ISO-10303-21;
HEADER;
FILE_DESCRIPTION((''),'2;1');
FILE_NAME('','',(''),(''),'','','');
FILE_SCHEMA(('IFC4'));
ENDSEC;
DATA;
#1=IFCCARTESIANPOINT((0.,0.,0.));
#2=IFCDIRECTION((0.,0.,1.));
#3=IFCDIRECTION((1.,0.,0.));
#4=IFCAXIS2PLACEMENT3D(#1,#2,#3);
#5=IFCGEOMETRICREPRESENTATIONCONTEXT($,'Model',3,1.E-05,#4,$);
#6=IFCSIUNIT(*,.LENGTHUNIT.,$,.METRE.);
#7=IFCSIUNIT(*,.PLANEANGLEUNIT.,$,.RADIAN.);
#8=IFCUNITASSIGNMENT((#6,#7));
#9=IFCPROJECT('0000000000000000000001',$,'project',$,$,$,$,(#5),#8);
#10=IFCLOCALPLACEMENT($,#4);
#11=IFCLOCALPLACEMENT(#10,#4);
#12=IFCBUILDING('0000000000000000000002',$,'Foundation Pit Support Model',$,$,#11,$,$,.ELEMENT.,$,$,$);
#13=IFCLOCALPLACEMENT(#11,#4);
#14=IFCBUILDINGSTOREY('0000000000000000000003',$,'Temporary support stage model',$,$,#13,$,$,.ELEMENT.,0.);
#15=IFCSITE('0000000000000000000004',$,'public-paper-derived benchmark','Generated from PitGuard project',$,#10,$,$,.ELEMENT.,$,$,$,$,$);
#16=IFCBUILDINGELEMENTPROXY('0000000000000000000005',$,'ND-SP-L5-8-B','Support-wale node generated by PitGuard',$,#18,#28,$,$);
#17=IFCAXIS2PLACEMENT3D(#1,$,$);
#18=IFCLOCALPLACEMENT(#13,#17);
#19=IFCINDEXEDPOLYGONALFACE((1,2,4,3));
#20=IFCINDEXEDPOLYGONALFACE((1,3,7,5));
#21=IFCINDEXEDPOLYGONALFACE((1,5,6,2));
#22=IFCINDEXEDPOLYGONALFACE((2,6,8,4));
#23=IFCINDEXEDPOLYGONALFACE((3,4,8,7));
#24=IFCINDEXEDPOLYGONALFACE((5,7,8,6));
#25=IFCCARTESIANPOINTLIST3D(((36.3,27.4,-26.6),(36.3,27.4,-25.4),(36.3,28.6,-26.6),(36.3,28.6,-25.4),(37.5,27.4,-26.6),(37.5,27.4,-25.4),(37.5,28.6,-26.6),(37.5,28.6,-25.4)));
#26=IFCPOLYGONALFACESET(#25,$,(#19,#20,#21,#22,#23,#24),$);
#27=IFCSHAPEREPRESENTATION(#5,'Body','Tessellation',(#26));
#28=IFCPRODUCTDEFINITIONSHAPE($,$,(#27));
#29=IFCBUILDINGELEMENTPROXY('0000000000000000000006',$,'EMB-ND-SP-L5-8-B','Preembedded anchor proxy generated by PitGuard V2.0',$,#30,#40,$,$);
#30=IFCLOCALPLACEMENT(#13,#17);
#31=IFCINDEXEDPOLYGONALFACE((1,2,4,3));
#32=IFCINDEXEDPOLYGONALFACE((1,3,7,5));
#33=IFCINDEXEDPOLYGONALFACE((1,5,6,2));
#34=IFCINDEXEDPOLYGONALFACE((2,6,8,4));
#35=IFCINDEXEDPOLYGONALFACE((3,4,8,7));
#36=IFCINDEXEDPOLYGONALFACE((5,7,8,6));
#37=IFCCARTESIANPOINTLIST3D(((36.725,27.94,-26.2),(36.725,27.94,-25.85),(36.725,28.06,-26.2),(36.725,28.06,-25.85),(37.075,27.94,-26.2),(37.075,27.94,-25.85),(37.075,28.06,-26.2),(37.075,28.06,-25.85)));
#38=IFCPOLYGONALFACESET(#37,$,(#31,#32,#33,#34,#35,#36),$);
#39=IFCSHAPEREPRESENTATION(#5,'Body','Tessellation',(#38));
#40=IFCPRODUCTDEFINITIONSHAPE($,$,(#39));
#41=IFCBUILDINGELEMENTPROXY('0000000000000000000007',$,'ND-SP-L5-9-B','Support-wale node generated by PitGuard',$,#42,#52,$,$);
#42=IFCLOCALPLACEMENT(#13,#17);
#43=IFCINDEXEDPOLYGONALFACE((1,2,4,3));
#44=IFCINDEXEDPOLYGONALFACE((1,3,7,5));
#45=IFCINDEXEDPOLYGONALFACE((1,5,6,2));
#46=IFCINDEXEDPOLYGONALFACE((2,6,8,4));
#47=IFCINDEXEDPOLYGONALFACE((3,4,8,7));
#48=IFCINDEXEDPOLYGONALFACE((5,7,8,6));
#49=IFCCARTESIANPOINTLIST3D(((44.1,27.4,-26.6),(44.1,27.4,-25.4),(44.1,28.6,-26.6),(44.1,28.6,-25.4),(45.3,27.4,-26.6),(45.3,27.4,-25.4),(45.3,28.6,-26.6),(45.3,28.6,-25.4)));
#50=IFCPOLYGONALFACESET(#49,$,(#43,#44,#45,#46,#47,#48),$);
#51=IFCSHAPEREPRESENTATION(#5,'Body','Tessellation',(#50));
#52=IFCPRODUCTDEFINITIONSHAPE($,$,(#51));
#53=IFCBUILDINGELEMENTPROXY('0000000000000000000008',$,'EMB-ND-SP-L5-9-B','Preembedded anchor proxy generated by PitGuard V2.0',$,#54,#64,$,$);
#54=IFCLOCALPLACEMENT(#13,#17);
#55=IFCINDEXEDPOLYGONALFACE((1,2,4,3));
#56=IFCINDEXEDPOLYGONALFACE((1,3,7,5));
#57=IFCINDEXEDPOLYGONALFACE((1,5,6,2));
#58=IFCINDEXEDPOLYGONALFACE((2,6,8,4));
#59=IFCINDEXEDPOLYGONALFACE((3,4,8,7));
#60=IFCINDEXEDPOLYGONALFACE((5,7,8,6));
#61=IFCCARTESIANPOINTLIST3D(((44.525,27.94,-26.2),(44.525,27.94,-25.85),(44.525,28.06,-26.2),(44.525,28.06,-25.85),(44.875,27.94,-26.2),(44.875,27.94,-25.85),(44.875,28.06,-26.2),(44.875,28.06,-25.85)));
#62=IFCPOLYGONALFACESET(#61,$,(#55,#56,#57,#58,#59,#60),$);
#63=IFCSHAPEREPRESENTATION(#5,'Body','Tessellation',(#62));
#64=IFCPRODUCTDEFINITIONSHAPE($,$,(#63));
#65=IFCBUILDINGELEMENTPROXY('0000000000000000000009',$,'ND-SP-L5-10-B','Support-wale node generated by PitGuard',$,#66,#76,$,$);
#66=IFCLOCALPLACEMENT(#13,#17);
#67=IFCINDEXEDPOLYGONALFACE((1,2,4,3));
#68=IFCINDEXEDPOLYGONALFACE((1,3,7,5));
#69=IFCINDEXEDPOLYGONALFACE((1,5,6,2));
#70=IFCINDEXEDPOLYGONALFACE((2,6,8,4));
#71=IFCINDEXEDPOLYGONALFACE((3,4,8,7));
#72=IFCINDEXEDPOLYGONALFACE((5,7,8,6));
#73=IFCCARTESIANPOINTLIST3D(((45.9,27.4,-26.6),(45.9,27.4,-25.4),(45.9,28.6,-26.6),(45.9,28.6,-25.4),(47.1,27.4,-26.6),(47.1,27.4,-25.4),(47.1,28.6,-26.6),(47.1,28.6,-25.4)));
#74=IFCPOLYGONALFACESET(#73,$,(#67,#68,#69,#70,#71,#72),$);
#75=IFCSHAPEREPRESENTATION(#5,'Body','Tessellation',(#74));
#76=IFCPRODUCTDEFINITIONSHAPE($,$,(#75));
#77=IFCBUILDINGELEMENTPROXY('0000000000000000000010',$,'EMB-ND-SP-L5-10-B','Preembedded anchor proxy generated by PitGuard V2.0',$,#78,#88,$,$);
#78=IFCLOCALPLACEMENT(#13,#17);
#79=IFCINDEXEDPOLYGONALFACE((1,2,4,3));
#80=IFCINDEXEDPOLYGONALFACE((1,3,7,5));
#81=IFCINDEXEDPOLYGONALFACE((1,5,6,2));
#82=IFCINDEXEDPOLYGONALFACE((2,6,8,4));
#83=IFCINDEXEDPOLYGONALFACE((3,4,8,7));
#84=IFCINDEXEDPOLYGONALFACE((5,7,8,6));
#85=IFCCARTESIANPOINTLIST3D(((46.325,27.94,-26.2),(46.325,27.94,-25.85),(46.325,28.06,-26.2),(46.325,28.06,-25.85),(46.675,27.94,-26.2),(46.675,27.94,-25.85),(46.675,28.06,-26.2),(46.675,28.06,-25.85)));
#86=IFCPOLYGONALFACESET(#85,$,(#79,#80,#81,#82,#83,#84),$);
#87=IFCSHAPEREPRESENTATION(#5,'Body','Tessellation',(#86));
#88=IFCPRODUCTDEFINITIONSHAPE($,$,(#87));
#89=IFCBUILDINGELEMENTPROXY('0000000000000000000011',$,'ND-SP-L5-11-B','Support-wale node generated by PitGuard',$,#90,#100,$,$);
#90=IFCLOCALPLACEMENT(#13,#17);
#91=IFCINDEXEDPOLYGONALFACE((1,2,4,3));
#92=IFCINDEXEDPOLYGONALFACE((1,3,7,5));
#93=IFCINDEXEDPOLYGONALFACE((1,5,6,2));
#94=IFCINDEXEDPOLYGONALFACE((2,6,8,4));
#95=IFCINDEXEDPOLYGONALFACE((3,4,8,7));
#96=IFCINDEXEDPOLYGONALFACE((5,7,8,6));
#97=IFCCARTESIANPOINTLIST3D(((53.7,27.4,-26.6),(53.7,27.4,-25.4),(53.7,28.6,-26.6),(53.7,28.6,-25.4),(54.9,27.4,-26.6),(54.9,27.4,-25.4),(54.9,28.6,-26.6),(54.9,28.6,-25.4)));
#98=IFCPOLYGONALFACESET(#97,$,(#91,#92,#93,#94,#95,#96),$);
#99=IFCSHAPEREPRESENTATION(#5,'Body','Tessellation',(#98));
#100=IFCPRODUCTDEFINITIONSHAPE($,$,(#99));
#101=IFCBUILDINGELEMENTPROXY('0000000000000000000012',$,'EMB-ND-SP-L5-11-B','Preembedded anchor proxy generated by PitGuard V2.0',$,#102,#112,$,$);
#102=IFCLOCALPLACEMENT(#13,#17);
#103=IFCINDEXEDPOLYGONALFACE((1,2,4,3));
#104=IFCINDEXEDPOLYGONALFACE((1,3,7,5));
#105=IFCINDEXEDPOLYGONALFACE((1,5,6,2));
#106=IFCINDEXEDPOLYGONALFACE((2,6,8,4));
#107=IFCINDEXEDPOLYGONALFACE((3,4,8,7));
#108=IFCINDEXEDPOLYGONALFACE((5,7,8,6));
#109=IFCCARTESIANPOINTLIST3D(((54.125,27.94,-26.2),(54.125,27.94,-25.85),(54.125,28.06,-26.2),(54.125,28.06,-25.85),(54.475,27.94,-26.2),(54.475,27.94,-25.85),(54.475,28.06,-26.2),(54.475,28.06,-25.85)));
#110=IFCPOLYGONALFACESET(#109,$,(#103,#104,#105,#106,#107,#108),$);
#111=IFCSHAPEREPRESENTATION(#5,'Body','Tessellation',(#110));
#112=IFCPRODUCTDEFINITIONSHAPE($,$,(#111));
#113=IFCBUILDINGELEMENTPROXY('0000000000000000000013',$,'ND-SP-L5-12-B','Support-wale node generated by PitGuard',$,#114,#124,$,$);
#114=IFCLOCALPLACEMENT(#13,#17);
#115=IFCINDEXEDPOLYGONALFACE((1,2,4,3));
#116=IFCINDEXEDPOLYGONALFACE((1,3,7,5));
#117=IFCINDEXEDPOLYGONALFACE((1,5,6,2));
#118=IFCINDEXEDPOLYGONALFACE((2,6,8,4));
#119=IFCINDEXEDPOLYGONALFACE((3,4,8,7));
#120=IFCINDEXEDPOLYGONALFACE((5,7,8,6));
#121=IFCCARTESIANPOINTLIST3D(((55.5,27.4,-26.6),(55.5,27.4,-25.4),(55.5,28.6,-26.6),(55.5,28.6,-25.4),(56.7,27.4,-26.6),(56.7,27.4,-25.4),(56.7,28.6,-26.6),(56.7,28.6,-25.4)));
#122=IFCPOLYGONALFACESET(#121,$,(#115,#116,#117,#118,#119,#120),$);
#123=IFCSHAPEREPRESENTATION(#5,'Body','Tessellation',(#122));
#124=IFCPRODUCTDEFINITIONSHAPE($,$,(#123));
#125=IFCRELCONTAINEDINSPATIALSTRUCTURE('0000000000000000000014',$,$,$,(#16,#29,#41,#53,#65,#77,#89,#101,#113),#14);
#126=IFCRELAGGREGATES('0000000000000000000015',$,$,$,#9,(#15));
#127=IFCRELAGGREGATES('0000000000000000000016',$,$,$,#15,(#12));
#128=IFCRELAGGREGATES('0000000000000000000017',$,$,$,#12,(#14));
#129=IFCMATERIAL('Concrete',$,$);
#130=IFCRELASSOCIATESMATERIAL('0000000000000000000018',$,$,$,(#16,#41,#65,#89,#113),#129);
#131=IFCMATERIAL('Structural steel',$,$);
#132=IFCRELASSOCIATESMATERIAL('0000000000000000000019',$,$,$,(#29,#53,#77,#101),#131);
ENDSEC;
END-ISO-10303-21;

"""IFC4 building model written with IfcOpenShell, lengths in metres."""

from ifc_helpers import new_model, si_unit, frame, origin_with_axes, origin_2d, place, context, project, spatial, rectangle, extrude, material, element, save


model = new_model("IFC4")

# Units and contexts
model_context = context("Model", 3, precision=1e-05, world=origin_with_axes())
ifc_project = project(units=[si_unit("LENGTHUNIT", "METRE"), si_unit("PLANEANGLEUNIT", "RADIAN")], contexts=[model_context])

# Site, building, storey
site_placement = place(None, origin_with_axes())
site = spatial("IfcSite", under=ifc_project, at=site_placement, Name="public-paper-derived benchmark", Description="Generated from PitGuard project", CompositionType="ELEMENT")
building_placement = place(site_placement, origin_with_axes())
building = spatial("IfcBuilding", under=site, at=building_placement, Name="Foundation Pit Support Model", CompositionType="ELEMENT")
storey_placement = place(building_placement, origin_with_axes())
storey = spatial("IfcBuildingStorey", under=building, at=storey_placement, Name="Temporary support stage model", CompositionType="ELEMENT", Elevation=0.0)

# Shared definitions
ifc_material_1 = material(Name="Structural steel")

# Shared definitions
ifc_material_2 = material(Name="Concrete")

# Building element proxies
proxy_1_placement = place(storey_placement, frame((36.9, 28.0, -26.6), z_axis=(0.0, 0.0, 1.0), x_axis=(1.0, 0.0, 0.0)))
element("IfcBuildingElementProxy", 1, at=proxy_1_placement, inside=storey, material=ifc_material_2, Name="ND-SP-L5-8-B", Description="Support-wale node generated by PitGuard", context=model_context, shape_type="SweptSolid", body=[
    extrude(rectangle(XDim=1.2, YDim=1.2, at=origin_2d()), origin_with_axes(), (0.0, 0.0, 1.0), 1.2),
])
proxy_2_placement = place(storey_placement, frame((36.9, 28.0, -26.2), z_axis=(0.0, 0.0, 1.0), x_axis=(1.0, 0.0, 0.0)))
element("IfcBuildingElementProxy", 2, at=proxy_2_placement, inside=storey, material=ifc_material_1, Name="EMB-ND-SP-L5-8-B", Description="Preembedded anchor proxy generated by PitGuard V2.0", context=model_context, shape_type="SweptSolid", body=[
    extrude(rectangle(XDim=0.35, YDim=0.12, at=origin_2d()), origin_with_axes(), (0.0, 0.0, 1.0), 0.35),
])
proxy_3_placement = place(storey_placement, frame((44.7, 28.0, -26.6), z_axis=(0.0, 0.0, 1.0), x_axis=(1.0, 0.0, 0.0)))
element("IfcBuildingElementProxy", 3, at=proxy_3_placement, inside=storey, material=ifc_material_2, Name="ND-SP-L5-9-B", Description="Support-wale node generated by PitGuard", context=model_context, shape_type="SweptSolid", body=[
    extrude(rectangle(XDim=1.2, YDim=1.2, at=origin_2d()), origin_with_axes(), (0.0, 0.0, 1.0), 1.2),
])
proxy_4_placement = place(storey_placement, frame((44.7, 28.0, -26.2), z_axis=(0.0, 0.0, 1.0), x_axis=(1.0, 0.0, 0.0)))
element("IfcBuildingElementProxy", 4, at=proxy_4_placement, inside=storey, material=ifc_material_1, Name="EMB-ND-SP-L5-9-B", Description="Preembedded anchor proxy generated by PitGuard V2.0", context=model_context, shape_type="SweptSolid", body=[
    extrude(rectangle(XDim=0.35, YDim=0.12, at=origin_2d()), origin_with_axes(), (0.0, 0.0, 1.0), 0.35),
])
proxy_5_placement = place(storey_placement, frame((46.5, 28.0, -26.6), z_axis=(0.0, 0.0, 1.0), x_axis=(1.0, 0.0, 0.0)))
element("IfcBuildingElementProxy", 5, at=proxy_5_placement, inside=storey, material=ifc_material_2, Name="ND-SP-L5-10-B", Description="Support-wale node generated by PitGuard", context=model_context, shape_type="SweptSolid", body=[
    extrude(rectangle(XDim=1.2, YDim=1.2, at=origin_2d()), origin_with_axes(), (0.0, 0.0, 1.0), 1.2),
])
proxy_6_placement = place(storey_placement, frame((46.5, 28.0, -26.2), z_axis=(0.0, 0.0, 1.0), x_axis=(1.0, 0.0, 0.0)))
element("IfcBuildingElementProxy", 6, at=proxy_6_placement, inside=storey, material=ifc_material_1, Name="EMB-ND-SP-L5-10-B", Description="Preembedded anchor proxy generated by PitGuard V2.0", context=model_context, shape_type="SweptSolid", body=[
    extrude(rectangle(XDim=0.35, YDim=0.12, at=origin_2d()), origin_with_axes(), (0.0, 0.0, 1.0), 0.35),
])
proxy_7_placement = place(storey_placement, frame((54.3, 28.0, -26.6), z_axis=(0.0, 0.0, 1.0), x_axis=(1.0, 0.0, 0.0)))
element("IfcBuildingElementProxy", 7, at=proxy_7_placement, inside=storey, material=ifc_material_2, Name="ND-SP-L5-11-B", Description="Support-wale node generated by PitGuard", context=model_context, shape_type="SweptSolid", body=[
    extrude(rectangle(XDim=1.2, YDim=1.2, at=origin_2d()), origin_with_axes(), (0.0, 0.0, 1.0), 1.2),
])
proxy_8_placement = place(storey_placement, frame((54.3, 28.0, -26.2), z_axis=(0.0, 0.0, 1.0), x_axis=(1.0, 0.0, 0.0)))
element("IfcBuildingElementProxy", 8, at=proxy_8_placement, inside=storey, material=ifc_material_1, Name="EMB-ND-SP-L5-11-B", Description="Preembedded anchor proxy generated by PitGuard V2.0", context=model_context, shape_type="SweptSolid", body=[
    extrude(rectangle(XDim=0.35, YDim=0.12, at=origin_2d()), origin_with_axes(), (0.0, 0.0, 1.0), 0.35),
])
proxy_9_placement = place(storey_placement, frame((56.1, 28.0, -26.6), z_axis=(0.0, 0.0, 1.0), x_axis=(1.0, 0.0, 0.0)))
element("IfcBuildingElementProxy", 9, at=proxy_9_placement, inside=storey, material=ifc_material_2, Name="ND-SP-L5-12-B", Description="Support-wale node generated by PitGuard", context=model_context, shape_type="SweptSolid", body=[
    extrude(rectangle(XDim=1.2, YDim=1.2, at=origin_2d()), origin_with_axes(), (0.0, 0.0, 1.0), 1.2),
])

save(model, "model.ifc")
